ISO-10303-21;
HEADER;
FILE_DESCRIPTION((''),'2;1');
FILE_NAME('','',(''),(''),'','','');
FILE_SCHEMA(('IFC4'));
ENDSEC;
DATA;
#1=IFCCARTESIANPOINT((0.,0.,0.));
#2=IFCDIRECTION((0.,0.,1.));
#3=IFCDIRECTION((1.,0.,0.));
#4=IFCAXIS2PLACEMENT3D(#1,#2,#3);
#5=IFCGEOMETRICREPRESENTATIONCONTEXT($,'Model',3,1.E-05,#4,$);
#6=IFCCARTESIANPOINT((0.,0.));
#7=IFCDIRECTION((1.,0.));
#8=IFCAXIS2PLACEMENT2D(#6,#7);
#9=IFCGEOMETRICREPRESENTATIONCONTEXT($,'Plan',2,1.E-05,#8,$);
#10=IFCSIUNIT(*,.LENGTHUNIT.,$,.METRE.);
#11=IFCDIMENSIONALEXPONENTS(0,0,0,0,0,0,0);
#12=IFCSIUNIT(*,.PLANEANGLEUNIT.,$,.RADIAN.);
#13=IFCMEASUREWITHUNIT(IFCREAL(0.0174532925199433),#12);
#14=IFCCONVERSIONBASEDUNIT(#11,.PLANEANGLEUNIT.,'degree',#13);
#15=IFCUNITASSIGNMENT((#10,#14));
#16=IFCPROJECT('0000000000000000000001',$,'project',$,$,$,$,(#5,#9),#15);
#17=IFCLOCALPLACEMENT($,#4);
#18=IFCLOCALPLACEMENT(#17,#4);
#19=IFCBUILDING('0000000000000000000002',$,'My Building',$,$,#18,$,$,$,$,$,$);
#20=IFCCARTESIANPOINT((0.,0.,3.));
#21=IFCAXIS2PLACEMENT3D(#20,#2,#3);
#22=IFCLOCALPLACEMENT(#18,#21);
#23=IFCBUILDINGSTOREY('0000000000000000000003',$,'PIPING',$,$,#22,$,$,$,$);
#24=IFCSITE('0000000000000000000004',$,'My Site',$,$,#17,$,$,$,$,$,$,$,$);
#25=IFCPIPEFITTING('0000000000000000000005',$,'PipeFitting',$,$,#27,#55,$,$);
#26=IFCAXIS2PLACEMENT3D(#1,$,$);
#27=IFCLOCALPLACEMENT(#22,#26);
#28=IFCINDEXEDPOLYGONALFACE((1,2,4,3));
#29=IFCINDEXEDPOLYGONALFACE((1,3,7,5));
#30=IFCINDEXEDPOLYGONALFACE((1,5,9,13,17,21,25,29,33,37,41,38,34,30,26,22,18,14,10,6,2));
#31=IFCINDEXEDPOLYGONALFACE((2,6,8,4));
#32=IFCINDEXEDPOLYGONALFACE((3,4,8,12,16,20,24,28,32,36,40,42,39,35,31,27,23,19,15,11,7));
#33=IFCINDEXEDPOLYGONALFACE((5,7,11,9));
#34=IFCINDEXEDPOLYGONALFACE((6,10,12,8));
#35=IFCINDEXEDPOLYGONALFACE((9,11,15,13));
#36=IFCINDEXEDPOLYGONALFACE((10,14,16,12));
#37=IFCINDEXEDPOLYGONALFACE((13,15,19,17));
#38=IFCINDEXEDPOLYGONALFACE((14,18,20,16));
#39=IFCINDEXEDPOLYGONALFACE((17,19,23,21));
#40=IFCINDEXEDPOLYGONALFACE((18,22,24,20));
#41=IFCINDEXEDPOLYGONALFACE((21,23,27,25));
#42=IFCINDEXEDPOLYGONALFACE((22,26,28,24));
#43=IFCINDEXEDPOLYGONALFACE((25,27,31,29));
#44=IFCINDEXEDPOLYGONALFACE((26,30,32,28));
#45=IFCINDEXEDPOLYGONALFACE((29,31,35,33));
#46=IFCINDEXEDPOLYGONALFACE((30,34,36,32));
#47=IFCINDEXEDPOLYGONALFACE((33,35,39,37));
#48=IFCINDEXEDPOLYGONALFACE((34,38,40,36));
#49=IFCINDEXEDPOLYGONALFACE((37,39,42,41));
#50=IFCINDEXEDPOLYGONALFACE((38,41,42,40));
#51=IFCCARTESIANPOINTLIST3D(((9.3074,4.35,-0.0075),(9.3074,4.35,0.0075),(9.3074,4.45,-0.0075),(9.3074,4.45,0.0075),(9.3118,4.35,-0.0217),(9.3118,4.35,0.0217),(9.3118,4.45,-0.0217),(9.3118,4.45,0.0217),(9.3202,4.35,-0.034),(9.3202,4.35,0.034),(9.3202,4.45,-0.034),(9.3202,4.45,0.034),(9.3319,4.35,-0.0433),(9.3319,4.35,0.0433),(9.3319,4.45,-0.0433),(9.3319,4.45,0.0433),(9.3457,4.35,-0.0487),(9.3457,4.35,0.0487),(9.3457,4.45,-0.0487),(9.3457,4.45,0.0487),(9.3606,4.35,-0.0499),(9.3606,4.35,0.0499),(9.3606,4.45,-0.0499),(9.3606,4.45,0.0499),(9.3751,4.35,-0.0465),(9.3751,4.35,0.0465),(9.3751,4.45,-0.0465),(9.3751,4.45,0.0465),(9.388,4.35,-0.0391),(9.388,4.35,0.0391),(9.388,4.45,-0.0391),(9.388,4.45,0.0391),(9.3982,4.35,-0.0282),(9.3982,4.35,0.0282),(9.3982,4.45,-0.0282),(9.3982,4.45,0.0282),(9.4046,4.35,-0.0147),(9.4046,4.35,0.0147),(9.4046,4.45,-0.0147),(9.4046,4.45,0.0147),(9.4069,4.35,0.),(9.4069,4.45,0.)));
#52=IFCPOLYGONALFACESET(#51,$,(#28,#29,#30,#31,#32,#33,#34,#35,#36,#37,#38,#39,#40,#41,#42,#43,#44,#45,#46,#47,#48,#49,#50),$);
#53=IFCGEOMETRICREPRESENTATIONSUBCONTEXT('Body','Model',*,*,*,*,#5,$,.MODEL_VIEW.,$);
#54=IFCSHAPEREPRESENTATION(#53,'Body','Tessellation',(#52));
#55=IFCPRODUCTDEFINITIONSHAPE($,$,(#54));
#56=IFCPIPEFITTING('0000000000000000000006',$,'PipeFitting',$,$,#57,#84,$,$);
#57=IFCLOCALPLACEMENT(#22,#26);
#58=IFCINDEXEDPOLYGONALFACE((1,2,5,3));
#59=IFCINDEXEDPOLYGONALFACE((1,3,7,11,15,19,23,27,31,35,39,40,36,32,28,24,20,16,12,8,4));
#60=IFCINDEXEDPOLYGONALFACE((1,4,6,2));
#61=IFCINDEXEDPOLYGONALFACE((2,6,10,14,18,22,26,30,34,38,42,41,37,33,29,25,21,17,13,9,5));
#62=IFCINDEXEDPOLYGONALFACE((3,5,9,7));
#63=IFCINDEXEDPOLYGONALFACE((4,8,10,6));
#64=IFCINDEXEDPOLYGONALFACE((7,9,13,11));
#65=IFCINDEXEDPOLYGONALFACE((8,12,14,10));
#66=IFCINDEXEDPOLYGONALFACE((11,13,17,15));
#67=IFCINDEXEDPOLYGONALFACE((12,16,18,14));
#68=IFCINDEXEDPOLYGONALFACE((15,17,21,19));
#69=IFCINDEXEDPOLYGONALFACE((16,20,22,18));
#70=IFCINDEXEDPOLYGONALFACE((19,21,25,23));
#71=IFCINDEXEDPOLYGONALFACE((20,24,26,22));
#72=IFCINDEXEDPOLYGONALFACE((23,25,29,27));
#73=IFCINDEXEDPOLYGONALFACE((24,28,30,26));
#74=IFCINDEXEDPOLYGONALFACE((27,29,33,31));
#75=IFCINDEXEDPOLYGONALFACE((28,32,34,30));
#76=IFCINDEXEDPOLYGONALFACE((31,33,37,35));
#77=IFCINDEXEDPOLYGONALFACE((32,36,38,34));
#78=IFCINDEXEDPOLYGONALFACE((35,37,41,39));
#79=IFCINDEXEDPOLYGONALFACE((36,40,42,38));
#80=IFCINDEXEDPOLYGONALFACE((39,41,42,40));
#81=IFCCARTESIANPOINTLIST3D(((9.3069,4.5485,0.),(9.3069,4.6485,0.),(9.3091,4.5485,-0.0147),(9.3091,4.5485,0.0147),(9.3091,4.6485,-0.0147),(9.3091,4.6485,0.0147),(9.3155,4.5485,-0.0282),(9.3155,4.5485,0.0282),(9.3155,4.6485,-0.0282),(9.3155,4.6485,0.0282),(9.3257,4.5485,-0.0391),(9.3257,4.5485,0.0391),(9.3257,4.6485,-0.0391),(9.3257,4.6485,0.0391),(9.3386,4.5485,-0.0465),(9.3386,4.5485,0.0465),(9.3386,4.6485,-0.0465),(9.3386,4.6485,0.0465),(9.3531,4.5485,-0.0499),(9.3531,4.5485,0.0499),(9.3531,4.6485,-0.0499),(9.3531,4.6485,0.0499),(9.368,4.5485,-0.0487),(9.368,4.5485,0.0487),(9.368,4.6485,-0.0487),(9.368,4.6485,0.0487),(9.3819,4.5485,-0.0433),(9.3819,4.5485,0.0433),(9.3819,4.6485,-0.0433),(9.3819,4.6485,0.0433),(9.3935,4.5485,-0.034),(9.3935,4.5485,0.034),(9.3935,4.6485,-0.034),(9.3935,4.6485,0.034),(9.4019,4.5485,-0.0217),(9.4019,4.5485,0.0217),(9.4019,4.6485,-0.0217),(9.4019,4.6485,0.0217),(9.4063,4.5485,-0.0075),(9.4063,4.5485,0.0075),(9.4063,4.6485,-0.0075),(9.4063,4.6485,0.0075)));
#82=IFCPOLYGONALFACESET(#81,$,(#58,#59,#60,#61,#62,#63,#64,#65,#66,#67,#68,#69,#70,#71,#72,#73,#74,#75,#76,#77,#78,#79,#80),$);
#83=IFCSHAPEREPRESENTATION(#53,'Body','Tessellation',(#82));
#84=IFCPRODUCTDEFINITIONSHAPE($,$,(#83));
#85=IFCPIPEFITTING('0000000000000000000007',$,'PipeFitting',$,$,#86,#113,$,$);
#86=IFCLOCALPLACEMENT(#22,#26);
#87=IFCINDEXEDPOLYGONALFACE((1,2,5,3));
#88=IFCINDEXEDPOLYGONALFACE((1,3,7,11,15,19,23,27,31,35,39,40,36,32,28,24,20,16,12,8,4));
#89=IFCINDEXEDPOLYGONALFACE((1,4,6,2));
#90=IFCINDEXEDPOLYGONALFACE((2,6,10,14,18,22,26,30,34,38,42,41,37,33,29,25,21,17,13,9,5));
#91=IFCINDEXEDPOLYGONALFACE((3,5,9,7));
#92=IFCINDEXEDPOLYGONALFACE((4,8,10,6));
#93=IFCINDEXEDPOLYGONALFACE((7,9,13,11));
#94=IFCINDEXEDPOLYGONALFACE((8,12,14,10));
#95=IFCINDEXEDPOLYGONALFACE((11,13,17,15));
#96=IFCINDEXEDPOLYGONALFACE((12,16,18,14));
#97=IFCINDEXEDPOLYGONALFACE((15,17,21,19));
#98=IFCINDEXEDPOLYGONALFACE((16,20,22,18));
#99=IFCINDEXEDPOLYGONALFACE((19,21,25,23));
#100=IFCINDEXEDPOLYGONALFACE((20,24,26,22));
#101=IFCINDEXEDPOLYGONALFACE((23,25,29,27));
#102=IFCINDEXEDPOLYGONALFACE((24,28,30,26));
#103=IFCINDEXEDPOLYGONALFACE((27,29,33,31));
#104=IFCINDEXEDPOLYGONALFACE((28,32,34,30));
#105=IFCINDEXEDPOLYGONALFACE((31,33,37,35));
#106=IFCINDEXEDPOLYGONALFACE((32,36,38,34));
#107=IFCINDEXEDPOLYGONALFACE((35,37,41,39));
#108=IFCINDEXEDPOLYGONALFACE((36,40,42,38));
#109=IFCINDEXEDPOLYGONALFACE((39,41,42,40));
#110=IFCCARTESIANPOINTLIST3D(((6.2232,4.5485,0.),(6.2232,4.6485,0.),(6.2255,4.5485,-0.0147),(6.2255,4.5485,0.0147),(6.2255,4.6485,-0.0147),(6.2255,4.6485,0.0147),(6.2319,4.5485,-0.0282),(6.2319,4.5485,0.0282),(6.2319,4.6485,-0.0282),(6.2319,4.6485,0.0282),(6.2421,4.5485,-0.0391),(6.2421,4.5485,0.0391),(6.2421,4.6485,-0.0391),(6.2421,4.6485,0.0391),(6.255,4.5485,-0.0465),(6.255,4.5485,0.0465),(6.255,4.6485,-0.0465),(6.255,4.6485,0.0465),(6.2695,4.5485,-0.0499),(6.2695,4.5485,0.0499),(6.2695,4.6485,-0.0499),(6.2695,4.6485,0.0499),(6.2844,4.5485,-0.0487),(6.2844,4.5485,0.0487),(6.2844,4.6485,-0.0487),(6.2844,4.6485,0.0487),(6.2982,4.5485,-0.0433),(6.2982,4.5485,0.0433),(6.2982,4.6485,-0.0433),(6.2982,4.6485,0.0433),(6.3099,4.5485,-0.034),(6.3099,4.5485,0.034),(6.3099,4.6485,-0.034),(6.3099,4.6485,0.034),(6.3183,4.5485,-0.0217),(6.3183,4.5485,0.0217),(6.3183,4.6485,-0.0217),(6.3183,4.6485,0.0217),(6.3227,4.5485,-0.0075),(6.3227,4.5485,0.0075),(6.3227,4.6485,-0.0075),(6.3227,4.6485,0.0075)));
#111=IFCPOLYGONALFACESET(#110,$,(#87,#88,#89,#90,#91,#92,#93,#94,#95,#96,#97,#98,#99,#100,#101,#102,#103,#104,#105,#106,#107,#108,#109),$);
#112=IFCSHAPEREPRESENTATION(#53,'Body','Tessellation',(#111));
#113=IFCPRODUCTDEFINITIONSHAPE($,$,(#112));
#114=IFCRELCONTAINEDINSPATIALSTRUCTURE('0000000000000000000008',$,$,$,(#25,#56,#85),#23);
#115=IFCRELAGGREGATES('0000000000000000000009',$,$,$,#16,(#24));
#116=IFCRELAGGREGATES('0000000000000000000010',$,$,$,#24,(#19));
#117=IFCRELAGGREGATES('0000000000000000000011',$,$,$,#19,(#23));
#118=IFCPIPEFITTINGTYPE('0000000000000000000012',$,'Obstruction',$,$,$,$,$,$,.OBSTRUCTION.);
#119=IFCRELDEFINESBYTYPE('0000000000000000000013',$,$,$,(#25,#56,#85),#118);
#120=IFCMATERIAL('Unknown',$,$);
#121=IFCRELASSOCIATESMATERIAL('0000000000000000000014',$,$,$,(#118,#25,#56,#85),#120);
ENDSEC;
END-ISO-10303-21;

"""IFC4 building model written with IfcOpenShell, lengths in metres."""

from ifc_helpers import new_model, entity, si_unit, converted_unit, frame, origin_with_axes, origin_2d_with_axis, place, context, subcontext, project, spatial, circle, extrude, material, material_profile, profile_set, profile_usage, type_object, element, save


model = new_model("IFC4")

# Units and contexts
model_context = context("Model", 3, precision=1e-05, world=origin_with_axes())
plan_context = context("Plan", 2, precision=1e-05, world=origin_2d_with_axis())
body_context = subcontext(model_context, "Body", "Model", "MODEL_VIEW")
ifc_project = project(units=[si_unit("LENGTHUNIT", "METRE"), converted_unit("PLANEANGLEUNIT", "degree", entity("IfcReal", 0.0174532925199433), si_unit("PLANEANGLEUNIT", "RADIAN"), dimensions=[0, 0, 0, 0, 0, 0, 0])], contexts=[model_context, plan_context])

# Site, building, storey
site_placement = place(None, origin_with_axes())
site = spatial("IfcSite", under=ifc_project, at=site_placement, Name="My Site")
building_placement = place(site_placement, origin_with_axes())
building = spatial("IfcBuilding", under=site, at=building_placement, Name="My Building")
storey_placement = place(building_placement, frame((0.0, 0.0, 3.0), z_axis=(0.0, 0.0, 1.0), x_axis=(1.0, 0.0, 0.0)))
storey = spatial("IfcBuildingStorey", under=building, at=storey_placement, Name="PIPING")

# Shared definitions
ifc_material = material(Name="Unknown")

# Pipe fittings
ifc_material_profile_1 = material_profile(ifc_material, circle(Radius=0.05))
ifc_profile_set_1 = profile_set([ifc_material_profile_1])
pipe_fitting_type_1 = type_object("IfcPipeFittingType", Name="Obstruction", PredefinedType="OBSTRUCTION", material=ifc_profile_set_1)
ifc_profile_usage_1 = profile_usage(ifc_profile_set_1, cardinal=5)
pipe_fitting_1_placement = place(storey_placement, frame((9.3569, 4.45, 0.0), z_axis=(0.0, -1.0, 0.0), x_axis=(1.0, 0.0, 0.0)))
element("IfcPipeFitting", 1, at=pipe_fitting_1_placement, inside=storey, type_object=pipe_fitting_type_1, material=ifc_profile_usage_1, Name="PipeFitting", context=body_context, shape_type="SweptSolid", body=[
    extrude(circle(Radius=0.05), origin_with_axes(), (0.0, 0.0, 1.0), 0.1),
])
ifc_profile_usage_2 = profile_usage(ifc_profile_set_1, cardinal=5)
pipe_fitting_2_placement = place(storey_placement, frame((9.3569, 4.5485, 0.0), z_axis=(0.0, 1.0, 0.0), x_axis=(-1.0, 0.0, 0.0)))
element("IfcPipeFitting", 2, at=pipe_fitting_2_placement, inside=storey, type_object=pipe_fitting_type_1, material=ifc_profile_usage_2, Name="PipeFitting", context=body_context, shape_type="SweptSolid", body=[
    extrude(circle(Radius=0.05), origin_with_axes(), (0.0, 0.0, 1.0), 0.1),
])
ifc_profile_usage_3 = profile_usage(ifc_profile_set_1, cardinal=5)
pipe_fitting_3_placement = place(storey_placement, frame((6.2732, 4.5485, 0.0), z_axis=(0.0, 1.0, 0.0), x_axis=(-1.0, 0.0, 0.0)))
element("IfcPipeFitting", 3, at=pipe_fitting_3_placement, inside=storey, type_object=pipe_fitting_type_1, material=ifc_profile_usage_3, Name="PipeFitting", context=body_context, shape_type="SweptSolid", body=[
    extrude(circle(Radius=0.05), origin_with_axes(), (0.0, 0.0, 1.0), 0.1),
])

save(model, "model.ifc")
